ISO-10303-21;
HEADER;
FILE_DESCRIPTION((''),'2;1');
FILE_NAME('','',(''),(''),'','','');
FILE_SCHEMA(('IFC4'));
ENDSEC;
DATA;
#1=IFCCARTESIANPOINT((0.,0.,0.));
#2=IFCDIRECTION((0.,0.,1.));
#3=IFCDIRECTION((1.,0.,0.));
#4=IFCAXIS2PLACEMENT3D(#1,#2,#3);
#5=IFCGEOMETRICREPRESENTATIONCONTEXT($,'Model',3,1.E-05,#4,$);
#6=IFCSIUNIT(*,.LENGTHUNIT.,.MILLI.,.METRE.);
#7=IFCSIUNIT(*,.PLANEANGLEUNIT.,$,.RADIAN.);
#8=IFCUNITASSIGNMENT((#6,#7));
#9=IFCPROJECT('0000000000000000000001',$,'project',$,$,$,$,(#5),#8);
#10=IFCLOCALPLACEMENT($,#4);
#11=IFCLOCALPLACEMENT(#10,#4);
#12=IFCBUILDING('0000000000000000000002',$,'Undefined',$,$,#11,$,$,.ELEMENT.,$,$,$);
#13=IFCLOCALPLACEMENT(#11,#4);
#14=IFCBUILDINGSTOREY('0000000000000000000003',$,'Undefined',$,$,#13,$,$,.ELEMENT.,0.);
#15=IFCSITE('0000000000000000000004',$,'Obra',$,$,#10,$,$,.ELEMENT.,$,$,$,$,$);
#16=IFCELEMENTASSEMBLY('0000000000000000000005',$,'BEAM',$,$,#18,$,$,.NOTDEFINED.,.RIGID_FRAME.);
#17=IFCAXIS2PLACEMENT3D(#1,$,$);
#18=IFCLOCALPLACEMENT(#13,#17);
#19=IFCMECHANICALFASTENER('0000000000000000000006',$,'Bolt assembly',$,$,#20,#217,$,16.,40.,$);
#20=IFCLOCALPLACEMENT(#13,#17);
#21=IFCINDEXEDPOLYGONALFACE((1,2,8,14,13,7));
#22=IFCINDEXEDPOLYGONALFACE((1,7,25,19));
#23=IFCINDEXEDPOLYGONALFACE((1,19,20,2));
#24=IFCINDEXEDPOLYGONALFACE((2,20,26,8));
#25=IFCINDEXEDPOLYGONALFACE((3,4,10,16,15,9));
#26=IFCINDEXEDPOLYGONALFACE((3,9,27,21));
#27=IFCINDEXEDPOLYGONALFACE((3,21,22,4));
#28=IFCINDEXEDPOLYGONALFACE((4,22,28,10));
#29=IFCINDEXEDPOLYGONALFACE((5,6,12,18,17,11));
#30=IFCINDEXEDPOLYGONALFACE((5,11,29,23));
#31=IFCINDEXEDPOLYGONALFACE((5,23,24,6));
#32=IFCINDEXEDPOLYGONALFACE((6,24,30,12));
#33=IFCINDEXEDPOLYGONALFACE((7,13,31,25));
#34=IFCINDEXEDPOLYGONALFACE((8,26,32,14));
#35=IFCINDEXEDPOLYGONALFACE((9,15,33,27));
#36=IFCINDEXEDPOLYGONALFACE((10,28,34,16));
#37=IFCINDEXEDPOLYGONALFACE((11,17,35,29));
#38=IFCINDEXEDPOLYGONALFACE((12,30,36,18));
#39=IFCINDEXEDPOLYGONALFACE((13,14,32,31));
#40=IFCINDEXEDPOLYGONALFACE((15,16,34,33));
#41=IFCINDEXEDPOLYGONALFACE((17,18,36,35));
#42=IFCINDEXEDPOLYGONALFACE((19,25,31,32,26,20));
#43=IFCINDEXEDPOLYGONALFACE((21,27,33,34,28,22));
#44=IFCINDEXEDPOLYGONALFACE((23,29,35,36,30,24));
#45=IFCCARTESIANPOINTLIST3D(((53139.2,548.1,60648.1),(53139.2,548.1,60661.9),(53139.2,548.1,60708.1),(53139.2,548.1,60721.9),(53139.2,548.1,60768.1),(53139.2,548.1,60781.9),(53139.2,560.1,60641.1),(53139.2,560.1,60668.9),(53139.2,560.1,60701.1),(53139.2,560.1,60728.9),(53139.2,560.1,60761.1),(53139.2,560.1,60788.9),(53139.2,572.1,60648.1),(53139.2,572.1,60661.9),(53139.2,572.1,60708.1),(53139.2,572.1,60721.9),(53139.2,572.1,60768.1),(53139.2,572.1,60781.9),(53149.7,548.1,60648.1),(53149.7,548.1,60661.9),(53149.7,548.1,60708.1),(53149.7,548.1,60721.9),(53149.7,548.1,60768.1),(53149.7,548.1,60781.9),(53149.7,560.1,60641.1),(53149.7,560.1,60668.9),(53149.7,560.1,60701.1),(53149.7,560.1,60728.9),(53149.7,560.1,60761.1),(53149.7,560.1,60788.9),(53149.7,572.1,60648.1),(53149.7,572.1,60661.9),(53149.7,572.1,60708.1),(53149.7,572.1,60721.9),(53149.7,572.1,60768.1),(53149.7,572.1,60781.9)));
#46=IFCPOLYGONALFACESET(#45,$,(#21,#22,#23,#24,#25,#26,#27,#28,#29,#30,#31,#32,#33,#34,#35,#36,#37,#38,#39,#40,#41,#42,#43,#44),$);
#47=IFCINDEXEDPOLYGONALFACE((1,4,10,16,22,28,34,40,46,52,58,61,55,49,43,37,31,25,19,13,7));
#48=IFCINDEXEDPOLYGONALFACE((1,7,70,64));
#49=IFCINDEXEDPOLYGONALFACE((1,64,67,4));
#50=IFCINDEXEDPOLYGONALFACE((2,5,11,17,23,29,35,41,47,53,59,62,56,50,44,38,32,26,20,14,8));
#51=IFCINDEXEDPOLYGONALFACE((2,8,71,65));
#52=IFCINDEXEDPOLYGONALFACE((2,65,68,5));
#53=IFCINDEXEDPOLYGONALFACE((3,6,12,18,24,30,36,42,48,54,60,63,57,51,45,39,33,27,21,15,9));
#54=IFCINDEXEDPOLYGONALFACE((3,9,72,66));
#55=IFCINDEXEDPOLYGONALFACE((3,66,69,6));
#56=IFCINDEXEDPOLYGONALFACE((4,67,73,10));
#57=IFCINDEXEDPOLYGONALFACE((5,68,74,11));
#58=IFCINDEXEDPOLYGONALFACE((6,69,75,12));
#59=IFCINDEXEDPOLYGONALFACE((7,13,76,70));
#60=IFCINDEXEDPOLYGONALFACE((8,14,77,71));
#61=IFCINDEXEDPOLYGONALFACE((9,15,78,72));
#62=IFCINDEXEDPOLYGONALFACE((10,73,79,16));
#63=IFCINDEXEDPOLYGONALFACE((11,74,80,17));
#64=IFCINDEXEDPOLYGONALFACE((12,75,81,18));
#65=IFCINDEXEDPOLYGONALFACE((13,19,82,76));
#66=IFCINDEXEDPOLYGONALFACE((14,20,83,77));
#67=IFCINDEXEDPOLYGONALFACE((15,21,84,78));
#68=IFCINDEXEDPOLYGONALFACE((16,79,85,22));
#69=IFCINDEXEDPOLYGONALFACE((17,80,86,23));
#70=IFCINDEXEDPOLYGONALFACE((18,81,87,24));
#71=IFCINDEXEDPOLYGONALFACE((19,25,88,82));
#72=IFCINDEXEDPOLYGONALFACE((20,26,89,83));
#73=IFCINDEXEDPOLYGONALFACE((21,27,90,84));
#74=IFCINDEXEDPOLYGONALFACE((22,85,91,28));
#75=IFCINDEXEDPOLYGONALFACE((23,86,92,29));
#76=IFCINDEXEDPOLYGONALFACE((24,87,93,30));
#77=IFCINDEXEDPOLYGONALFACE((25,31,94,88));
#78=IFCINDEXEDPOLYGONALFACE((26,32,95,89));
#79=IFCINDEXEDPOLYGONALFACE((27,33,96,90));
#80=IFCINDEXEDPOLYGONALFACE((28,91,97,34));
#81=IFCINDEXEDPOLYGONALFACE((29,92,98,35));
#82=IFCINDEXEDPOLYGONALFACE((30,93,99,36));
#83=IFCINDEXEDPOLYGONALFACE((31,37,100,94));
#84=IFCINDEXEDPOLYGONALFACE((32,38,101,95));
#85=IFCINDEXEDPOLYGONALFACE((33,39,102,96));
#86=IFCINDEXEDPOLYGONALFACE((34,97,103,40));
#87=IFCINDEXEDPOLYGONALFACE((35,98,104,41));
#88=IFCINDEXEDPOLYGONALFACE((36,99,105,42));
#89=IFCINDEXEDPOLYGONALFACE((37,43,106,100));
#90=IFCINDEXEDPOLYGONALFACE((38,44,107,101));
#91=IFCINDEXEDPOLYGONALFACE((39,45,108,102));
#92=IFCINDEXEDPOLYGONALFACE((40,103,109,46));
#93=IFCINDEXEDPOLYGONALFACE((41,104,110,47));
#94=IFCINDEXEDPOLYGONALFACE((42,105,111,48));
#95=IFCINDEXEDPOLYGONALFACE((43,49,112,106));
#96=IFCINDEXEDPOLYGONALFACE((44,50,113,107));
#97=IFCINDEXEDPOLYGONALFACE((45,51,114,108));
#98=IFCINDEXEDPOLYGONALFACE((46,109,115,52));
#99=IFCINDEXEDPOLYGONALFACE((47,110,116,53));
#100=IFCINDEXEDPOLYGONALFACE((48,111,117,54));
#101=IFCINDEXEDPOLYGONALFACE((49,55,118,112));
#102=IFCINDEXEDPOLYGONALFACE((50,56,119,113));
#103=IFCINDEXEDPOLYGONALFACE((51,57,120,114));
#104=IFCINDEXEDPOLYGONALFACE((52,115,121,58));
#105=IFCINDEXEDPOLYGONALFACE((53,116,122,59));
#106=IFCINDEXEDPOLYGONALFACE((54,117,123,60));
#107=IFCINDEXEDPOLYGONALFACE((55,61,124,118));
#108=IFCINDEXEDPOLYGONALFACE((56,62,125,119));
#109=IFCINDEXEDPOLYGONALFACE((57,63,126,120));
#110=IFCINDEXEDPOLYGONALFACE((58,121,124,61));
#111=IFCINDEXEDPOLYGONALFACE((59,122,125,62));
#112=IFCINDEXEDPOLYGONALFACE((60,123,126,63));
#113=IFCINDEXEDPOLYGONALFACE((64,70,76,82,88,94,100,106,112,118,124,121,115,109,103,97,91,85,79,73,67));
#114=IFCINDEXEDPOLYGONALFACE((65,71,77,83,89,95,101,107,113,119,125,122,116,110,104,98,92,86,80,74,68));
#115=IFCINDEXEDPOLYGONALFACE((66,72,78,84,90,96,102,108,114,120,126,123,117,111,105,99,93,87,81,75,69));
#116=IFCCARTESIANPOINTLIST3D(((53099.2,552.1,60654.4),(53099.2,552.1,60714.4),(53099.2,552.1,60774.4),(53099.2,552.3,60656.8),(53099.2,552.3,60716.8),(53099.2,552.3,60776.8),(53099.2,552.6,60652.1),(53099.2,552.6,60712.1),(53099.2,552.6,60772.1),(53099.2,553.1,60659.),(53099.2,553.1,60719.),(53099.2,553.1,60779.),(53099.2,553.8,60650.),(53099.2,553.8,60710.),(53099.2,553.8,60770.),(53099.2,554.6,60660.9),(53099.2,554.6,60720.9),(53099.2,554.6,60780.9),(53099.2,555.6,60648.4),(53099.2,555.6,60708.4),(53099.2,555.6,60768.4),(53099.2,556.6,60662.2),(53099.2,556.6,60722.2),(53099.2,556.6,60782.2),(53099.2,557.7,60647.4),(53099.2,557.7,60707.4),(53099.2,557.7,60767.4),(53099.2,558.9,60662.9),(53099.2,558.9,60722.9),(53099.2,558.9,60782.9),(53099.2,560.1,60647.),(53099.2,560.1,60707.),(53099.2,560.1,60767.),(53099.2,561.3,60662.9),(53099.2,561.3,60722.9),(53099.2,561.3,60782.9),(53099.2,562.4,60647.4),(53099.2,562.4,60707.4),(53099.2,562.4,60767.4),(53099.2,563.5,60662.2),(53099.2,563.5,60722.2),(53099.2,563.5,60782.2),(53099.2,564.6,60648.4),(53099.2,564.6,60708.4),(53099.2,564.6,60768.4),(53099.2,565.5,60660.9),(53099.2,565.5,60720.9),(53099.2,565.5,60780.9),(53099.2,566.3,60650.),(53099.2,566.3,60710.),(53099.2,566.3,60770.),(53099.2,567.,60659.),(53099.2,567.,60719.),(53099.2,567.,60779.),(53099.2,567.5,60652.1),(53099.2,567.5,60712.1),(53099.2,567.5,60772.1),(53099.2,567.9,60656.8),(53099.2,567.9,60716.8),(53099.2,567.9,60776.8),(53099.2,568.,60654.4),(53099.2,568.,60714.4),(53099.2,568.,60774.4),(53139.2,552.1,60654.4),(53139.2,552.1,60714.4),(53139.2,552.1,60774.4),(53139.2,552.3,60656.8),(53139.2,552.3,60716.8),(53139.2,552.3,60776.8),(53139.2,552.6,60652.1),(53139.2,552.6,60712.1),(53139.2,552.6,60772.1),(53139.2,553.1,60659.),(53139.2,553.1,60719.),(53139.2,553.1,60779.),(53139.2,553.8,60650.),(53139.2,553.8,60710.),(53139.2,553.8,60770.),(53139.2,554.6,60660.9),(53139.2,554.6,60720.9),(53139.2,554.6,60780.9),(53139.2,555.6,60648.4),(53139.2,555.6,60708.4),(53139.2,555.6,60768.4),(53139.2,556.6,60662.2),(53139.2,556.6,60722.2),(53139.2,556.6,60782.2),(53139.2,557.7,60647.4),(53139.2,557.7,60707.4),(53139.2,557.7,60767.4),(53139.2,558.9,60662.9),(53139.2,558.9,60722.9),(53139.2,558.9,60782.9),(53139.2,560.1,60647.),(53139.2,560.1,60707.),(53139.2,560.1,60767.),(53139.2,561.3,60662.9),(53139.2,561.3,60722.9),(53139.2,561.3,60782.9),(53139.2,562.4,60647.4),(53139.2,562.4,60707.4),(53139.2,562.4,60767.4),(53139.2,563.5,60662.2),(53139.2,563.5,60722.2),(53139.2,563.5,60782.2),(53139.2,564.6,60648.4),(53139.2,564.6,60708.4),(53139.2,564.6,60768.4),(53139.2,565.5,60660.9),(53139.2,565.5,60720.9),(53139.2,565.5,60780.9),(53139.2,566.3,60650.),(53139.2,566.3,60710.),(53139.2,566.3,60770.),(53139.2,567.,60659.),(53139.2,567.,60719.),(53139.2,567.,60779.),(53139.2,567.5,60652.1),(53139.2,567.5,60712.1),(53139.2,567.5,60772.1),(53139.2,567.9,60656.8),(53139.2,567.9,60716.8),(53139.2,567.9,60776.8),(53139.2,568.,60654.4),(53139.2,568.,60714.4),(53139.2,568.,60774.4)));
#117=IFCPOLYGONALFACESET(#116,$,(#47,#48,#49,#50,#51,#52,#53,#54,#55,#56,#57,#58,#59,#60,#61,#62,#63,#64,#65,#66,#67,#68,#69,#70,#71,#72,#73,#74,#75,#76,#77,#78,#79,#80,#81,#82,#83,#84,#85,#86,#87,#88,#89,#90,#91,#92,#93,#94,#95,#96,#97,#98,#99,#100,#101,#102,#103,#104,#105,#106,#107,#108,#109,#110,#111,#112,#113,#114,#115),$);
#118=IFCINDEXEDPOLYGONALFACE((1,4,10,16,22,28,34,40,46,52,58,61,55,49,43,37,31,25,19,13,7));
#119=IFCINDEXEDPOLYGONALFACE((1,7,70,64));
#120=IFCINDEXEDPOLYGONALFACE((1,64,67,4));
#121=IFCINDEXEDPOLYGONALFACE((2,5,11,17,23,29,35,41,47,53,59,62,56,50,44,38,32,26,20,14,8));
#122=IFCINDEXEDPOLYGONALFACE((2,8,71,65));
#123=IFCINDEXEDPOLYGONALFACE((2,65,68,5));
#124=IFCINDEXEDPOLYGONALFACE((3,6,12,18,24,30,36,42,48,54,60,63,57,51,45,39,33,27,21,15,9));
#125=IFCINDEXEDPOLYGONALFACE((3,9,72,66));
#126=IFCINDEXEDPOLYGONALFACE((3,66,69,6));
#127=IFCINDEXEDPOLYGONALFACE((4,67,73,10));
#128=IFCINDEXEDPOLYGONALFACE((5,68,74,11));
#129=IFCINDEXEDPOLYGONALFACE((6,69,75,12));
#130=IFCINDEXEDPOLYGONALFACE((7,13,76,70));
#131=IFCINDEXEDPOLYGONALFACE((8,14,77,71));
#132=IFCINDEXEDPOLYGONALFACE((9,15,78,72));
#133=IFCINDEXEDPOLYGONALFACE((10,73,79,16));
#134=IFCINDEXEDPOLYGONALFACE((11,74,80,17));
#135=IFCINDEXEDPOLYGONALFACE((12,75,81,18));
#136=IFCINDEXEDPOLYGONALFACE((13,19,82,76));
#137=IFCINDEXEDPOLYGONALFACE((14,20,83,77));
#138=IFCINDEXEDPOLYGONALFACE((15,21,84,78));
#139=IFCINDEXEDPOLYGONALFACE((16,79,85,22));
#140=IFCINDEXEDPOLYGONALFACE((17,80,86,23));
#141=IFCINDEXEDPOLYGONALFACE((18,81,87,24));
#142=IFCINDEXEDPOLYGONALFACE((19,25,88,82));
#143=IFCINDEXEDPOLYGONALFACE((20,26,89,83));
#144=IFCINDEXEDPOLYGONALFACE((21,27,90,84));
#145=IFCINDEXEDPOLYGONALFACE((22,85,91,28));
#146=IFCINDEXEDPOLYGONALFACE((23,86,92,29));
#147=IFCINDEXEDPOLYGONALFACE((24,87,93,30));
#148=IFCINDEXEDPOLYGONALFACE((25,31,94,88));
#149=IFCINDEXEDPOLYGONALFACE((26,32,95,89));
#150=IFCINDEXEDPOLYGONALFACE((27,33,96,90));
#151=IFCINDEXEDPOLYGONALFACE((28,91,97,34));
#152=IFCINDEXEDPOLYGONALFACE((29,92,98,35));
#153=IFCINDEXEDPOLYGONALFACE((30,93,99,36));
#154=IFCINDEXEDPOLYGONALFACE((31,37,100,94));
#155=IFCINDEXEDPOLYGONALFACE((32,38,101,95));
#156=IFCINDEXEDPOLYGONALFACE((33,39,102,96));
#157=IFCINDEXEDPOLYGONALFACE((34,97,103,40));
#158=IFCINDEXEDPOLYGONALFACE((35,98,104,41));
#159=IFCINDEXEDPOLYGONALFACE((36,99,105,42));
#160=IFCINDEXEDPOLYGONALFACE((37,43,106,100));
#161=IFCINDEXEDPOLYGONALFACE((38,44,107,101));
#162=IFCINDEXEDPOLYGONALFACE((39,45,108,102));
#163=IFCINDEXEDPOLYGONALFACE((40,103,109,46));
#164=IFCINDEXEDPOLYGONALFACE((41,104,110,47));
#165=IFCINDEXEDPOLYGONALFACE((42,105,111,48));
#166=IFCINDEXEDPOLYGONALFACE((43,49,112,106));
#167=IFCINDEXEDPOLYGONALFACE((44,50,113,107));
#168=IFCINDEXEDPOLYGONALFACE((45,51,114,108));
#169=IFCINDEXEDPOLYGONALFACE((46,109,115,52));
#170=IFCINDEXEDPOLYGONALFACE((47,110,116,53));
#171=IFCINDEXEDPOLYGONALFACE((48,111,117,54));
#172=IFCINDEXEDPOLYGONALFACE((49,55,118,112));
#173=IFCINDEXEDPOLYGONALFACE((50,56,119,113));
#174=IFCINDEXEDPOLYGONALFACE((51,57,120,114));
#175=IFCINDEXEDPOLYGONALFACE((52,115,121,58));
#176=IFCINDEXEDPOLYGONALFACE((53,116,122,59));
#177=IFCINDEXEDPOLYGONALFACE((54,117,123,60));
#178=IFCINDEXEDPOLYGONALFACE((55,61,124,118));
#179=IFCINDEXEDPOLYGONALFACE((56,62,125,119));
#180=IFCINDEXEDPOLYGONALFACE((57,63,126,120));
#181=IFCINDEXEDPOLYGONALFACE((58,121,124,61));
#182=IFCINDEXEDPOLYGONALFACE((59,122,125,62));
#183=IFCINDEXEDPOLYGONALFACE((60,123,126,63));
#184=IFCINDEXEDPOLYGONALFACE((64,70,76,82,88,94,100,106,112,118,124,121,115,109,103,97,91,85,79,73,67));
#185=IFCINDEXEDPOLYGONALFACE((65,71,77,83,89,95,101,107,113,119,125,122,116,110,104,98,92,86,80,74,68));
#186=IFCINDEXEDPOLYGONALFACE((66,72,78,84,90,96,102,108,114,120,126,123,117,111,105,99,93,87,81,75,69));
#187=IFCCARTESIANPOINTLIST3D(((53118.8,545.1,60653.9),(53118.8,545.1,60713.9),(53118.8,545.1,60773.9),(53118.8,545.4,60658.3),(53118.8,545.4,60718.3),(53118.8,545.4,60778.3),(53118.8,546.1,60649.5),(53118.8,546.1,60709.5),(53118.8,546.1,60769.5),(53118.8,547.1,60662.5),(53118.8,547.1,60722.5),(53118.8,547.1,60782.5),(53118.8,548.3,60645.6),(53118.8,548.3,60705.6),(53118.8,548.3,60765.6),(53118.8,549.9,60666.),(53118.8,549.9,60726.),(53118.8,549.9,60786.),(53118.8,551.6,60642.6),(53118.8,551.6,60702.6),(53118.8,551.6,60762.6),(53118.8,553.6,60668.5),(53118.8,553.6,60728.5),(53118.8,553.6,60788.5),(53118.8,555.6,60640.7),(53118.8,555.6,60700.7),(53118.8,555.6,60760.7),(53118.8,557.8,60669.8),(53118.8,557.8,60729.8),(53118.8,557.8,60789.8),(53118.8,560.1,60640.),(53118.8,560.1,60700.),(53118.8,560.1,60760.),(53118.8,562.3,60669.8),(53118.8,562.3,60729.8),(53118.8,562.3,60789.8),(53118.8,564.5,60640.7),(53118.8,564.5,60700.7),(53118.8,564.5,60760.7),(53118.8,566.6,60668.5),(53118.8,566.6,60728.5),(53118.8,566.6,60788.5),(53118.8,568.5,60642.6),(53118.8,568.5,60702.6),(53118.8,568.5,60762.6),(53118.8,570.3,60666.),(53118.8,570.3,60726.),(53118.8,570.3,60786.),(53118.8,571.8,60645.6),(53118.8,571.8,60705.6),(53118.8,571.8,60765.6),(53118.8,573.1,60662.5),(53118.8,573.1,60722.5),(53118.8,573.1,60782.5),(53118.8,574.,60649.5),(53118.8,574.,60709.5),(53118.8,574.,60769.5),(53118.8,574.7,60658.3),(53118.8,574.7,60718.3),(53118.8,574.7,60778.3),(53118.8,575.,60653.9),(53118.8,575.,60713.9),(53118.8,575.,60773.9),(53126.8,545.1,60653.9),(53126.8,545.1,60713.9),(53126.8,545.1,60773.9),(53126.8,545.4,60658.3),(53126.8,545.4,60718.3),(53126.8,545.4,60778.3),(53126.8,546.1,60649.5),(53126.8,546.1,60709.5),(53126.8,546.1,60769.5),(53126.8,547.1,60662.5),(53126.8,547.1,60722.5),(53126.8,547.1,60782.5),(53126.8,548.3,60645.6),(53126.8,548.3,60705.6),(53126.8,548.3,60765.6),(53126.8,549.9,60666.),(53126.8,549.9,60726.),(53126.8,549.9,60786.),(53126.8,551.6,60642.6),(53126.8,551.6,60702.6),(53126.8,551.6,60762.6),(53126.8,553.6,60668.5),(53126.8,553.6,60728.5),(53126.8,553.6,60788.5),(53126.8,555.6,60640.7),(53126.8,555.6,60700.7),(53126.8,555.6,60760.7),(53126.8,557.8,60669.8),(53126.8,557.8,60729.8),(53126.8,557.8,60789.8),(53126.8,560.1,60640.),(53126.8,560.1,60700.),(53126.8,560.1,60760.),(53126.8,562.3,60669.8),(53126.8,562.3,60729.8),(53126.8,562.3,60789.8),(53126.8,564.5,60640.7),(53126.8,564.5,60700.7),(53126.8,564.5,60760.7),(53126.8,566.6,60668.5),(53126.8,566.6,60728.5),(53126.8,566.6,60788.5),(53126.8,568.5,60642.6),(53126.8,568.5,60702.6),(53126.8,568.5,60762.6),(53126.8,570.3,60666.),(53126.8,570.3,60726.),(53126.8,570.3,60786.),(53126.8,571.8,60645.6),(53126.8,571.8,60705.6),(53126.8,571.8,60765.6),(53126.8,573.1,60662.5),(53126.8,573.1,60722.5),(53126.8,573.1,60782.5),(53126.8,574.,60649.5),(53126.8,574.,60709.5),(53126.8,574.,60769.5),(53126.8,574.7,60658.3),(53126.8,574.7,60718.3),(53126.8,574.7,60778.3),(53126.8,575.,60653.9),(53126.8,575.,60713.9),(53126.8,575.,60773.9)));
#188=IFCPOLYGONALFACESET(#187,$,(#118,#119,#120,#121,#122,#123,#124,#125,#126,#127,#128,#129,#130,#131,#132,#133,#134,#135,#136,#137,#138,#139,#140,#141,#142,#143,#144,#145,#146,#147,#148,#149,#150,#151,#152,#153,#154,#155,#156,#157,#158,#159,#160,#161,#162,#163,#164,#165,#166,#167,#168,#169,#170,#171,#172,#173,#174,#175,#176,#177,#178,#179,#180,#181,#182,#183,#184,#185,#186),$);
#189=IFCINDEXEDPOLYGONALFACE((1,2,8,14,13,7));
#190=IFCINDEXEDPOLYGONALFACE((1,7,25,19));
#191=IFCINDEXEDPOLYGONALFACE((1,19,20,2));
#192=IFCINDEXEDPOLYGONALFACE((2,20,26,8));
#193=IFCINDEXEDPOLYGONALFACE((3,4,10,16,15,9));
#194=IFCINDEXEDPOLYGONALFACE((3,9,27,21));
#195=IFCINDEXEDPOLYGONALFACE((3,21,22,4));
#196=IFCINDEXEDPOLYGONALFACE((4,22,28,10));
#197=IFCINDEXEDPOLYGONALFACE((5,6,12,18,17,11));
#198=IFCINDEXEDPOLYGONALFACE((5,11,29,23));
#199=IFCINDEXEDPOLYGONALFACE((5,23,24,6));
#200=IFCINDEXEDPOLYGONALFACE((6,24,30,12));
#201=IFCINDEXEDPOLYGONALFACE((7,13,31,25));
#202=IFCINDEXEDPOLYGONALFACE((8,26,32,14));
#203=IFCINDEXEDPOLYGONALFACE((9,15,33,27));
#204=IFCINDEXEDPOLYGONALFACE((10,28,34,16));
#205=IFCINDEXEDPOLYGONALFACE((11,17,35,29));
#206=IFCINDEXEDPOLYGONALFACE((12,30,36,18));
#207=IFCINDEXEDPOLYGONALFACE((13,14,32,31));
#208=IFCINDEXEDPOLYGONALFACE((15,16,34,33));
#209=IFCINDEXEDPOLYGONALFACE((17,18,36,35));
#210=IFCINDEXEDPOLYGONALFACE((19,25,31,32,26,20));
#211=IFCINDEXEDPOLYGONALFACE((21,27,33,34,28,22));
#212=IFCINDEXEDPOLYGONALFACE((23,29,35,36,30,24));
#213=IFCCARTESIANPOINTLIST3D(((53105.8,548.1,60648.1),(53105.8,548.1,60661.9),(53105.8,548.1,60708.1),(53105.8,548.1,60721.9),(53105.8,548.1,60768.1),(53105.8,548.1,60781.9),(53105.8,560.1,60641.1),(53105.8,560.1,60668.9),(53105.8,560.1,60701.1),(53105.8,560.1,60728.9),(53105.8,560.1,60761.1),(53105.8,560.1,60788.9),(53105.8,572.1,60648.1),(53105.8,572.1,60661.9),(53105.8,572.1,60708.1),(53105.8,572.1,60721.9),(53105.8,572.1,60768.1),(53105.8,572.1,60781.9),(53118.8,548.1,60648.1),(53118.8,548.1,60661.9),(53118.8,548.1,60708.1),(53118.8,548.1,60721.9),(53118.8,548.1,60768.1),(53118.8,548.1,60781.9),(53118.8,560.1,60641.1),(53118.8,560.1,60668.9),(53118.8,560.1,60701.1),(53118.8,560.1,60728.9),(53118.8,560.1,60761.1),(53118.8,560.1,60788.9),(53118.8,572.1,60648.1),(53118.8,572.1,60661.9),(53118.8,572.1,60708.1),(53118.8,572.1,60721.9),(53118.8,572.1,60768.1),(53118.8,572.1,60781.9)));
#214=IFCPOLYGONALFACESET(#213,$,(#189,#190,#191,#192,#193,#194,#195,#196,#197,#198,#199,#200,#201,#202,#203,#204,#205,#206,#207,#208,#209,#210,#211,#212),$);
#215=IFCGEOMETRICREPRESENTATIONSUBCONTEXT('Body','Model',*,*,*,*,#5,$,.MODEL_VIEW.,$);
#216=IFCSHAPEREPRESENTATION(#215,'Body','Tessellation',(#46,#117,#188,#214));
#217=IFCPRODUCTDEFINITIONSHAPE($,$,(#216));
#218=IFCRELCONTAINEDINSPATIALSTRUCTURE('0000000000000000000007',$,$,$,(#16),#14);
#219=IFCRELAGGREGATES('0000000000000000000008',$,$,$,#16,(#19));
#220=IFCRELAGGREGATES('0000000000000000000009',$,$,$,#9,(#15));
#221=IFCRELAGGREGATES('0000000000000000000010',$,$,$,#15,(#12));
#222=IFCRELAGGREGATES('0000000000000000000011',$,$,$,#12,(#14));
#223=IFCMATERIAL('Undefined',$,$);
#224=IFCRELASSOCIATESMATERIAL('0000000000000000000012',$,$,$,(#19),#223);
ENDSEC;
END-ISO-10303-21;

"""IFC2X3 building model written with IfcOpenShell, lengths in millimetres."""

from ifc_helpers import new_model, si_unit, frame, origin_with_axes, origin_2d_with_axis, place, context, subcontext, project, spatial, polyline, circle, outline, extrude, source, transform, mapped, material, element, aggregate, save


model = new_model("IFC2X3")

# Units and contexts
model_context = context("Model", 3, precision=1e-05, world=origin_with_axes())
body_context = subcontext(model_context, "Body", "Model", "MODEL_VIEW")
ifc_project = project(units=[si_unit("LENGTHUNIT", "METRE", prefix="MILLI"), si_unit("PLANEANGLEUNIT", "RADIAN")], contexts=[model_context])

# Site, building, storey
site_placement = place(None, origin_with_axes())
site = spatial("IfcSite", under=ifc_project, at=site_placement, Name="Obra", CompositionType="ELEMENT")
building_placement = place(site_placement, origin_with_axes())
building = spatial("IfcBuilding", under=site, at=building_placement, Name="Undefined", CompositionType="ELEMENT")
storey_placement = place(building_placement, origin_with_axes())
storey = spatial("IfcBuildingStorey", under=building, at=storey_placement, Name="Undefined", CompositionType="ELEMENT", Elevation=0.0)

# Element assembly
ifc_material_1 = material(Name="Undefined")
assembly_1_placement = place(storey_placement, origin_with_axes())
assembly_1 = element("IfcElementAssembly", 1, at=assembly_1_placement, inside=storey, Name="BEAM", AssemblyPlace="NOTDEFINED", PredefinedType="RIGID_FRAME")

# Mechanical fastener
shared_shape_1 = source(origin_with_axes(), body_context, "Body", "SweptSolid", [
    extrude(outline(polyline([(13.9, 0.0), (6.9, 12.0), (-6.9, 12.0), (-13.9, 0.0), (-6.9, -12.0), (6.9, -12.0), (13.9, 0.0)])), frame((0.0, -19.7, 0.0), z_axis=(0.0, 1.0, 0.0), x_axis=(1.0, 0.0, 0.0)), (0.0, 0.0, 1.0), 10.6),
    extrude(circle(Radius=8.0, at=origin_2d_with_axis()), frame((0.0, -9.1, 0.0), z_axis=(0.0, 1.0, 0.0), x_axis=(1.0, 0.0, 0.0)), (0.0, 0.0, 1.0), 40.0),
    extrude(circle(Radius=15.0, at=origin_2d_with_axis()), frame((0.0, 3.3, 0.0), z_axis=(0.0, 1.0, 0.0), x_axis=(1.0, 0.0, 0.0)), (0.0, 0.0, 1.0), 8.0),
    extrude(outline(polyline([(13.9, 0.0), (6.9, 12.0), (-6.9, 12.0), (-13.9, 0.0), (-6.9, -12.0), (6.9, -12.0), (13.9, 0.0)])), frame((0.0, 11.3, 0.0), z_axis=(0.0, 1.0, 0.0), x_axis=(1.0, 0.0, 0.0)), (0.0, 0.0, 1.0), 13.0),
])
mechanical_fastener_1_placement = place(assembly_1_placement, frame((53130.1, 510.1, 60835.0), z_axis=(-0.000002, 1.0, 0.0), x_axis=(0.0, 0.0, -1.0)))
mechanical_fastener_1 = element("IfcMechanicalFastener", 2, at=mechanical_fastener_1_placement, material=ifc_material_1, Name="Bolt assembly", NominalDiameter=16.0, NominalLength=40.0, context=body_context, shape_type="MappedRepresentation", body=[
    mapped(shared_shape_1, transform((60.0, 0.0, 50.0))),
    mapped(shared_shape_1, transform((120.0, 0.0, 50.0))),
    mapped(shared_shape_1, transform((180.0, 0.0, 50.0))),
])
aggregate(assembly_1, [mechanical_fastener_1])

save(model, "model.ifc")
